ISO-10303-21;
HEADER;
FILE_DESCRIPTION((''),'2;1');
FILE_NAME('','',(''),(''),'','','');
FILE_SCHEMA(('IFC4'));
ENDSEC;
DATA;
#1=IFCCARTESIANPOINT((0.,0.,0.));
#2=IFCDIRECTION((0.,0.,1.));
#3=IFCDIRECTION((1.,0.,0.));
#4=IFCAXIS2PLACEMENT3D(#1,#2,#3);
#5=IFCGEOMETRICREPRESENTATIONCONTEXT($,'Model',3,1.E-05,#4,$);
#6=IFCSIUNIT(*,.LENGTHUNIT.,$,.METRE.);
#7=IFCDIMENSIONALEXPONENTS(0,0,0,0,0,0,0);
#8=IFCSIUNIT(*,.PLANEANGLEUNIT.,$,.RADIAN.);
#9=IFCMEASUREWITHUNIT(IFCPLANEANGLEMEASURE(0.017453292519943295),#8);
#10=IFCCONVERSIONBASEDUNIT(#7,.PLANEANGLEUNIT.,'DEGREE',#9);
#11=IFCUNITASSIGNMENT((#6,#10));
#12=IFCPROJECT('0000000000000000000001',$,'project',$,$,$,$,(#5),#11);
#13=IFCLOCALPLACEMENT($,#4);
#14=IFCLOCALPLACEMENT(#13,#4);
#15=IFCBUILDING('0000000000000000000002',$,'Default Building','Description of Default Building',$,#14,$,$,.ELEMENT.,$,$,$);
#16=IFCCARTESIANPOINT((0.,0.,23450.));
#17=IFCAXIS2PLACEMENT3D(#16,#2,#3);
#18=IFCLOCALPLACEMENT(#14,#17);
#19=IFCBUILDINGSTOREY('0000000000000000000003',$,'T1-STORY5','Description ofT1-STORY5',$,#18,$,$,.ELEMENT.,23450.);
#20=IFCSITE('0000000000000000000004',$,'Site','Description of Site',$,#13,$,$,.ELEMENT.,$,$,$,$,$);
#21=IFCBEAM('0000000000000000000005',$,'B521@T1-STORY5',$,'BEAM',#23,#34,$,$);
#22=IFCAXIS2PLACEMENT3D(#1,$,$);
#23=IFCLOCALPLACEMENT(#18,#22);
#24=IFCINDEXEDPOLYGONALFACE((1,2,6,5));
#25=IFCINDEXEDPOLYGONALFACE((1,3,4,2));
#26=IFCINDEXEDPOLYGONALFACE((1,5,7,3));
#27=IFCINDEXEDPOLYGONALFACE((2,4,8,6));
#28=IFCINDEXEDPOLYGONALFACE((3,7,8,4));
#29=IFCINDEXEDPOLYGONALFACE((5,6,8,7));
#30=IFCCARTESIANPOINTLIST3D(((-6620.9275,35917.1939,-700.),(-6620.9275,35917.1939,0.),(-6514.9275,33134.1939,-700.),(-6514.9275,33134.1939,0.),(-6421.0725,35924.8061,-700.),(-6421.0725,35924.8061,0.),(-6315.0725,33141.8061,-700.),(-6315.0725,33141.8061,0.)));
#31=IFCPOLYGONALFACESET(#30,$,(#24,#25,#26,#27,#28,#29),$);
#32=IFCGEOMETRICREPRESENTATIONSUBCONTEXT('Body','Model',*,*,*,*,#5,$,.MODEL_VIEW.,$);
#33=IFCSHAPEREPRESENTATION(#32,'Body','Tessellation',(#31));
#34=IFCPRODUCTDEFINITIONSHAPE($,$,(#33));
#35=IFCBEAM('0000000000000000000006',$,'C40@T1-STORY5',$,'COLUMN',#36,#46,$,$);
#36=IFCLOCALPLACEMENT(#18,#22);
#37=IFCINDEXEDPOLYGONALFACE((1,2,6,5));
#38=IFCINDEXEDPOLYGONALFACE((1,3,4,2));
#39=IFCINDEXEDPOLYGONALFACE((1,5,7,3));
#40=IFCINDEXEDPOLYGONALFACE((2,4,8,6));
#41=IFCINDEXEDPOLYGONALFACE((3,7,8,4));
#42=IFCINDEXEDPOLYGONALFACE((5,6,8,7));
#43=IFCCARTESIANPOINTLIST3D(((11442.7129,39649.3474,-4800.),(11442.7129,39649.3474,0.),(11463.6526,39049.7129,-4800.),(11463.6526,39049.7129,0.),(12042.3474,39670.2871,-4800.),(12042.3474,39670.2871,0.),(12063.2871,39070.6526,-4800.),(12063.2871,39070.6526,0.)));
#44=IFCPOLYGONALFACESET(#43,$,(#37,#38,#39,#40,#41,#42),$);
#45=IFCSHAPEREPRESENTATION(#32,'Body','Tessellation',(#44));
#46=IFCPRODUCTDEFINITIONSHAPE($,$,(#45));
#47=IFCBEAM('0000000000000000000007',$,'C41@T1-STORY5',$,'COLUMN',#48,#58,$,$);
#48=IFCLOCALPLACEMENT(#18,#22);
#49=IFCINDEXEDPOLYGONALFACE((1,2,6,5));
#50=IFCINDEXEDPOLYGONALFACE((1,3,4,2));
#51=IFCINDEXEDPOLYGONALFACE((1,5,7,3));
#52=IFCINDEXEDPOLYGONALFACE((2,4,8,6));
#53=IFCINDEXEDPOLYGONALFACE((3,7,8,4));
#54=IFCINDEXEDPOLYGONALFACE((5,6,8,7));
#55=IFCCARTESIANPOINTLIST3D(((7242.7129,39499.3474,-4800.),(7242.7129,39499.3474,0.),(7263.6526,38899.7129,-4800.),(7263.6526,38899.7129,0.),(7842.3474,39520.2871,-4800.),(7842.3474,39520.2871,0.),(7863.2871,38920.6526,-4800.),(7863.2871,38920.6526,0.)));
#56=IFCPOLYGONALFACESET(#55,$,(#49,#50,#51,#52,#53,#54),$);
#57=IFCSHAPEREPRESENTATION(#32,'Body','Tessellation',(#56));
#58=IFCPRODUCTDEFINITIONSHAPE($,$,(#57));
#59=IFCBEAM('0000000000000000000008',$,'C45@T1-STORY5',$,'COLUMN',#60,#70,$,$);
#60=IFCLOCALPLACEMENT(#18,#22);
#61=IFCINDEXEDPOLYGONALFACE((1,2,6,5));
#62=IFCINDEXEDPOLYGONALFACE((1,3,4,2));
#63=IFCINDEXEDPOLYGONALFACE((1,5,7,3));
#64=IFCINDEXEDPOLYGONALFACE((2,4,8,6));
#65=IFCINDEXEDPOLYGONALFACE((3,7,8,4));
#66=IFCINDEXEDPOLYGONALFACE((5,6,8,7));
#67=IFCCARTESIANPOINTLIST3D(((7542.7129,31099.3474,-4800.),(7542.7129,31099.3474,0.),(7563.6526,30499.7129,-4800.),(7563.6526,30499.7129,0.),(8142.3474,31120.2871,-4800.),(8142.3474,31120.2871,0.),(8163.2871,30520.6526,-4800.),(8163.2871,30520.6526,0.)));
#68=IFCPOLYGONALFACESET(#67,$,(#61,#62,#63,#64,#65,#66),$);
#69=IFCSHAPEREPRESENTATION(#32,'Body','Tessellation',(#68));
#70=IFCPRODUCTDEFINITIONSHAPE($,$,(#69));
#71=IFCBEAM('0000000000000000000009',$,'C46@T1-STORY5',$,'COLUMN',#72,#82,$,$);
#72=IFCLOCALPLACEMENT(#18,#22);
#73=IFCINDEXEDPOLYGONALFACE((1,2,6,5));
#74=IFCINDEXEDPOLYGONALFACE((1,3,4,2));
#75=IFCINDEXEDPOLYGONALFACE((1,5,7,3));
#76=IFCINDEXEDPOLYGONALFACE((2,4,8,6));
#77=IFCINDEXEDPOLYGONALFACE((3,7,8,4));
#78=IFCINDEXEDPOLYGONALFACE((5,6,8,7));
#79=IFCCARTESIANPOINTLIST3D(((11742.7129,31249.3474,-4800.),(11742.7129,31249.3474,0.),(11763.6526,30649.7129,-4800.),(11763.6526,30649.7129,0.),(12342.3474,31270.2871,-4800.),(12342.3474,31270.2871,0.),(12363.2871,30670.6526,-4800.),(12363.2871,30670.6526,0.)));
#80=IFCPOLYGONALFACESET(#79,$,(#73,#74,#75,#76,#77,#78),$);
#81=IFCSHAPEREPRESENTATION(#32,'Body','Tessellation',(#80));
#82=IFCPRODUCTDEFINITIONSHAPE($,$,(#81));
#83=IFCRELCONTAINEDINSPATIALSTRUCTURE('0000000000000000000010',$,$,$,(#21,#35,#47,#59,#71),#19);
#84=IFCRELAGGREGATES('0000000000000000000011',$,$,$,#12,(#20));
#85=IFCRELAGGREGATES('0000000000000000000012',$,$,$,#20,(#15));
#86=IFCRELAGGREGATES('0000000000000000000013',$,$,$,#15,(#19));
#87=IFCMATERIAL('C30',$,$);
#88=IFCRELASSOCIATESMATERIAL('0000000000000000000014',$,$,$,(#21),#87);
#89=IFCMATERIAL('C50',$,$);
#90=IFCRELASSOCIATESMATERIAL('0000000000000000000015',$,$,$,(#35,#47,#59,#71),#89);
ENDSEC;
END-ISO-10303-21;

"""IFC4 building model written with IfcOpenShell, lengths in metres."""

from ifc_helpers import new_model, entity, si_unit, converted_unit, frame, origin_with_axes, place, context, subcontext, project, spatial, rectangle, extrude, material, element, save


model = new_model("IFC4")

# Units and contexts
model_context = context("Model", 3, precision=1e-05, world=origin_with_axes())
body_context = subcontext(model_context, "Body", "Model", "MODEL_VIEW")
ifc_project = project(units=[si_unit("LENGTHUNIT", "METRE"), converted_unit("PLANEANGLEUNIT", "DEGREE", entity("IfcPlaneAngleMeasure", 0.017453292519943295), si_unit("PLANEANGLEUNIT", "RADIAN"), dimensions=[0, 0, 0, 0, 0, 0, 0])], contexts=[model_context])

# Site, building, storey
site_placement = place(None, origin_with_axes())
site = spatial("IfcSite", under=ifc_project, at=site_placement, Name="Site", Description="Description of Site", CompositionType="ELEMENT")
building_placement = place(site_placement, origin_with_axes())
building = spatial("IfcBuilding", under=site, at=building_placement, Name="Default Building", Description="Description of Default Building", CompositionType="ELEMENT")
storey_placement = place(building_placement, frame((0.0, 0.0, 23450.0), z_axis=(0.0, 0.0, 1.0), x_axis=(1.0, 0.0, 0.0)))
storey = spatial("IfcBuildingStorey", under=building, at=storey_placement, Name="T1-STORY5", Description="Description ofT1-STORY5", CompositionType="ELEMENT", Elevation=23450.0)

# Beams
ifc_material_1 = material(Name="C30")
beam_1_placement = place(storey_placement, frame((-6521.0, 35921.0, -350.0), z_axis=(0.038061, -0.999275, 0.0), x_axis=(0.999275, 0.038061, 0.0)))
element("IfcBeam", 1, at=beam_1_placement, inside=storey, material=ifc_material_1, Name="B521@T1-STORY5", ObjectType="BEAM", context=body_context, shape_type="SweptSolid", body=[
    extrude(rectangle(XDim=200.0, YDim=700.0), origin_with_axes(), (0.0, 0.0, 1.0), 2785.018),
])
ifc_material_2 = material(Name="C50")
for number, where, z_axis, x_axis, name in (
    (2, (11753.0, 39360.0, -4800.0), (0.0, 0.0, 1.0), (-0.999391, -0.034899, 0.0), "C40@T1-STORY5"),
    (3, (7553.0, 39210.0, -4800.0), (0.0, 0.0, 1.0), (-0.999391, -0.034899, 0.0), "C41@T1-STORY5"),
    (4, (7853.0, 30810.0, -4800.0), (0.0, 0.0, 1.0), (-0.999391, -0.034899, 0.0), "C45@T1-STORY5"),
    (5, (12053.0, 30960.0, -4800.0), (0.0, 0.0, 1.0), (-0.999391, -0.034899, 0.0), "C46@T1-STORY5"),
):
    element("IfcBeam", number, at=place(storey_placement, frame(where, z_axis=z_axis, x_axis=x_axis)), inside=storey, material=ifc_material_2, Name=name, ObjectType="COLUMN", context=body_context, shape_type="SweptSolid", body=[
        extrude(rectangle(XDim=600.0, YDim=600.0), origin_with_axes(), (0.0, 0.0, 1.0), 4800.0),
    ])

save(model, "model.ifc")
